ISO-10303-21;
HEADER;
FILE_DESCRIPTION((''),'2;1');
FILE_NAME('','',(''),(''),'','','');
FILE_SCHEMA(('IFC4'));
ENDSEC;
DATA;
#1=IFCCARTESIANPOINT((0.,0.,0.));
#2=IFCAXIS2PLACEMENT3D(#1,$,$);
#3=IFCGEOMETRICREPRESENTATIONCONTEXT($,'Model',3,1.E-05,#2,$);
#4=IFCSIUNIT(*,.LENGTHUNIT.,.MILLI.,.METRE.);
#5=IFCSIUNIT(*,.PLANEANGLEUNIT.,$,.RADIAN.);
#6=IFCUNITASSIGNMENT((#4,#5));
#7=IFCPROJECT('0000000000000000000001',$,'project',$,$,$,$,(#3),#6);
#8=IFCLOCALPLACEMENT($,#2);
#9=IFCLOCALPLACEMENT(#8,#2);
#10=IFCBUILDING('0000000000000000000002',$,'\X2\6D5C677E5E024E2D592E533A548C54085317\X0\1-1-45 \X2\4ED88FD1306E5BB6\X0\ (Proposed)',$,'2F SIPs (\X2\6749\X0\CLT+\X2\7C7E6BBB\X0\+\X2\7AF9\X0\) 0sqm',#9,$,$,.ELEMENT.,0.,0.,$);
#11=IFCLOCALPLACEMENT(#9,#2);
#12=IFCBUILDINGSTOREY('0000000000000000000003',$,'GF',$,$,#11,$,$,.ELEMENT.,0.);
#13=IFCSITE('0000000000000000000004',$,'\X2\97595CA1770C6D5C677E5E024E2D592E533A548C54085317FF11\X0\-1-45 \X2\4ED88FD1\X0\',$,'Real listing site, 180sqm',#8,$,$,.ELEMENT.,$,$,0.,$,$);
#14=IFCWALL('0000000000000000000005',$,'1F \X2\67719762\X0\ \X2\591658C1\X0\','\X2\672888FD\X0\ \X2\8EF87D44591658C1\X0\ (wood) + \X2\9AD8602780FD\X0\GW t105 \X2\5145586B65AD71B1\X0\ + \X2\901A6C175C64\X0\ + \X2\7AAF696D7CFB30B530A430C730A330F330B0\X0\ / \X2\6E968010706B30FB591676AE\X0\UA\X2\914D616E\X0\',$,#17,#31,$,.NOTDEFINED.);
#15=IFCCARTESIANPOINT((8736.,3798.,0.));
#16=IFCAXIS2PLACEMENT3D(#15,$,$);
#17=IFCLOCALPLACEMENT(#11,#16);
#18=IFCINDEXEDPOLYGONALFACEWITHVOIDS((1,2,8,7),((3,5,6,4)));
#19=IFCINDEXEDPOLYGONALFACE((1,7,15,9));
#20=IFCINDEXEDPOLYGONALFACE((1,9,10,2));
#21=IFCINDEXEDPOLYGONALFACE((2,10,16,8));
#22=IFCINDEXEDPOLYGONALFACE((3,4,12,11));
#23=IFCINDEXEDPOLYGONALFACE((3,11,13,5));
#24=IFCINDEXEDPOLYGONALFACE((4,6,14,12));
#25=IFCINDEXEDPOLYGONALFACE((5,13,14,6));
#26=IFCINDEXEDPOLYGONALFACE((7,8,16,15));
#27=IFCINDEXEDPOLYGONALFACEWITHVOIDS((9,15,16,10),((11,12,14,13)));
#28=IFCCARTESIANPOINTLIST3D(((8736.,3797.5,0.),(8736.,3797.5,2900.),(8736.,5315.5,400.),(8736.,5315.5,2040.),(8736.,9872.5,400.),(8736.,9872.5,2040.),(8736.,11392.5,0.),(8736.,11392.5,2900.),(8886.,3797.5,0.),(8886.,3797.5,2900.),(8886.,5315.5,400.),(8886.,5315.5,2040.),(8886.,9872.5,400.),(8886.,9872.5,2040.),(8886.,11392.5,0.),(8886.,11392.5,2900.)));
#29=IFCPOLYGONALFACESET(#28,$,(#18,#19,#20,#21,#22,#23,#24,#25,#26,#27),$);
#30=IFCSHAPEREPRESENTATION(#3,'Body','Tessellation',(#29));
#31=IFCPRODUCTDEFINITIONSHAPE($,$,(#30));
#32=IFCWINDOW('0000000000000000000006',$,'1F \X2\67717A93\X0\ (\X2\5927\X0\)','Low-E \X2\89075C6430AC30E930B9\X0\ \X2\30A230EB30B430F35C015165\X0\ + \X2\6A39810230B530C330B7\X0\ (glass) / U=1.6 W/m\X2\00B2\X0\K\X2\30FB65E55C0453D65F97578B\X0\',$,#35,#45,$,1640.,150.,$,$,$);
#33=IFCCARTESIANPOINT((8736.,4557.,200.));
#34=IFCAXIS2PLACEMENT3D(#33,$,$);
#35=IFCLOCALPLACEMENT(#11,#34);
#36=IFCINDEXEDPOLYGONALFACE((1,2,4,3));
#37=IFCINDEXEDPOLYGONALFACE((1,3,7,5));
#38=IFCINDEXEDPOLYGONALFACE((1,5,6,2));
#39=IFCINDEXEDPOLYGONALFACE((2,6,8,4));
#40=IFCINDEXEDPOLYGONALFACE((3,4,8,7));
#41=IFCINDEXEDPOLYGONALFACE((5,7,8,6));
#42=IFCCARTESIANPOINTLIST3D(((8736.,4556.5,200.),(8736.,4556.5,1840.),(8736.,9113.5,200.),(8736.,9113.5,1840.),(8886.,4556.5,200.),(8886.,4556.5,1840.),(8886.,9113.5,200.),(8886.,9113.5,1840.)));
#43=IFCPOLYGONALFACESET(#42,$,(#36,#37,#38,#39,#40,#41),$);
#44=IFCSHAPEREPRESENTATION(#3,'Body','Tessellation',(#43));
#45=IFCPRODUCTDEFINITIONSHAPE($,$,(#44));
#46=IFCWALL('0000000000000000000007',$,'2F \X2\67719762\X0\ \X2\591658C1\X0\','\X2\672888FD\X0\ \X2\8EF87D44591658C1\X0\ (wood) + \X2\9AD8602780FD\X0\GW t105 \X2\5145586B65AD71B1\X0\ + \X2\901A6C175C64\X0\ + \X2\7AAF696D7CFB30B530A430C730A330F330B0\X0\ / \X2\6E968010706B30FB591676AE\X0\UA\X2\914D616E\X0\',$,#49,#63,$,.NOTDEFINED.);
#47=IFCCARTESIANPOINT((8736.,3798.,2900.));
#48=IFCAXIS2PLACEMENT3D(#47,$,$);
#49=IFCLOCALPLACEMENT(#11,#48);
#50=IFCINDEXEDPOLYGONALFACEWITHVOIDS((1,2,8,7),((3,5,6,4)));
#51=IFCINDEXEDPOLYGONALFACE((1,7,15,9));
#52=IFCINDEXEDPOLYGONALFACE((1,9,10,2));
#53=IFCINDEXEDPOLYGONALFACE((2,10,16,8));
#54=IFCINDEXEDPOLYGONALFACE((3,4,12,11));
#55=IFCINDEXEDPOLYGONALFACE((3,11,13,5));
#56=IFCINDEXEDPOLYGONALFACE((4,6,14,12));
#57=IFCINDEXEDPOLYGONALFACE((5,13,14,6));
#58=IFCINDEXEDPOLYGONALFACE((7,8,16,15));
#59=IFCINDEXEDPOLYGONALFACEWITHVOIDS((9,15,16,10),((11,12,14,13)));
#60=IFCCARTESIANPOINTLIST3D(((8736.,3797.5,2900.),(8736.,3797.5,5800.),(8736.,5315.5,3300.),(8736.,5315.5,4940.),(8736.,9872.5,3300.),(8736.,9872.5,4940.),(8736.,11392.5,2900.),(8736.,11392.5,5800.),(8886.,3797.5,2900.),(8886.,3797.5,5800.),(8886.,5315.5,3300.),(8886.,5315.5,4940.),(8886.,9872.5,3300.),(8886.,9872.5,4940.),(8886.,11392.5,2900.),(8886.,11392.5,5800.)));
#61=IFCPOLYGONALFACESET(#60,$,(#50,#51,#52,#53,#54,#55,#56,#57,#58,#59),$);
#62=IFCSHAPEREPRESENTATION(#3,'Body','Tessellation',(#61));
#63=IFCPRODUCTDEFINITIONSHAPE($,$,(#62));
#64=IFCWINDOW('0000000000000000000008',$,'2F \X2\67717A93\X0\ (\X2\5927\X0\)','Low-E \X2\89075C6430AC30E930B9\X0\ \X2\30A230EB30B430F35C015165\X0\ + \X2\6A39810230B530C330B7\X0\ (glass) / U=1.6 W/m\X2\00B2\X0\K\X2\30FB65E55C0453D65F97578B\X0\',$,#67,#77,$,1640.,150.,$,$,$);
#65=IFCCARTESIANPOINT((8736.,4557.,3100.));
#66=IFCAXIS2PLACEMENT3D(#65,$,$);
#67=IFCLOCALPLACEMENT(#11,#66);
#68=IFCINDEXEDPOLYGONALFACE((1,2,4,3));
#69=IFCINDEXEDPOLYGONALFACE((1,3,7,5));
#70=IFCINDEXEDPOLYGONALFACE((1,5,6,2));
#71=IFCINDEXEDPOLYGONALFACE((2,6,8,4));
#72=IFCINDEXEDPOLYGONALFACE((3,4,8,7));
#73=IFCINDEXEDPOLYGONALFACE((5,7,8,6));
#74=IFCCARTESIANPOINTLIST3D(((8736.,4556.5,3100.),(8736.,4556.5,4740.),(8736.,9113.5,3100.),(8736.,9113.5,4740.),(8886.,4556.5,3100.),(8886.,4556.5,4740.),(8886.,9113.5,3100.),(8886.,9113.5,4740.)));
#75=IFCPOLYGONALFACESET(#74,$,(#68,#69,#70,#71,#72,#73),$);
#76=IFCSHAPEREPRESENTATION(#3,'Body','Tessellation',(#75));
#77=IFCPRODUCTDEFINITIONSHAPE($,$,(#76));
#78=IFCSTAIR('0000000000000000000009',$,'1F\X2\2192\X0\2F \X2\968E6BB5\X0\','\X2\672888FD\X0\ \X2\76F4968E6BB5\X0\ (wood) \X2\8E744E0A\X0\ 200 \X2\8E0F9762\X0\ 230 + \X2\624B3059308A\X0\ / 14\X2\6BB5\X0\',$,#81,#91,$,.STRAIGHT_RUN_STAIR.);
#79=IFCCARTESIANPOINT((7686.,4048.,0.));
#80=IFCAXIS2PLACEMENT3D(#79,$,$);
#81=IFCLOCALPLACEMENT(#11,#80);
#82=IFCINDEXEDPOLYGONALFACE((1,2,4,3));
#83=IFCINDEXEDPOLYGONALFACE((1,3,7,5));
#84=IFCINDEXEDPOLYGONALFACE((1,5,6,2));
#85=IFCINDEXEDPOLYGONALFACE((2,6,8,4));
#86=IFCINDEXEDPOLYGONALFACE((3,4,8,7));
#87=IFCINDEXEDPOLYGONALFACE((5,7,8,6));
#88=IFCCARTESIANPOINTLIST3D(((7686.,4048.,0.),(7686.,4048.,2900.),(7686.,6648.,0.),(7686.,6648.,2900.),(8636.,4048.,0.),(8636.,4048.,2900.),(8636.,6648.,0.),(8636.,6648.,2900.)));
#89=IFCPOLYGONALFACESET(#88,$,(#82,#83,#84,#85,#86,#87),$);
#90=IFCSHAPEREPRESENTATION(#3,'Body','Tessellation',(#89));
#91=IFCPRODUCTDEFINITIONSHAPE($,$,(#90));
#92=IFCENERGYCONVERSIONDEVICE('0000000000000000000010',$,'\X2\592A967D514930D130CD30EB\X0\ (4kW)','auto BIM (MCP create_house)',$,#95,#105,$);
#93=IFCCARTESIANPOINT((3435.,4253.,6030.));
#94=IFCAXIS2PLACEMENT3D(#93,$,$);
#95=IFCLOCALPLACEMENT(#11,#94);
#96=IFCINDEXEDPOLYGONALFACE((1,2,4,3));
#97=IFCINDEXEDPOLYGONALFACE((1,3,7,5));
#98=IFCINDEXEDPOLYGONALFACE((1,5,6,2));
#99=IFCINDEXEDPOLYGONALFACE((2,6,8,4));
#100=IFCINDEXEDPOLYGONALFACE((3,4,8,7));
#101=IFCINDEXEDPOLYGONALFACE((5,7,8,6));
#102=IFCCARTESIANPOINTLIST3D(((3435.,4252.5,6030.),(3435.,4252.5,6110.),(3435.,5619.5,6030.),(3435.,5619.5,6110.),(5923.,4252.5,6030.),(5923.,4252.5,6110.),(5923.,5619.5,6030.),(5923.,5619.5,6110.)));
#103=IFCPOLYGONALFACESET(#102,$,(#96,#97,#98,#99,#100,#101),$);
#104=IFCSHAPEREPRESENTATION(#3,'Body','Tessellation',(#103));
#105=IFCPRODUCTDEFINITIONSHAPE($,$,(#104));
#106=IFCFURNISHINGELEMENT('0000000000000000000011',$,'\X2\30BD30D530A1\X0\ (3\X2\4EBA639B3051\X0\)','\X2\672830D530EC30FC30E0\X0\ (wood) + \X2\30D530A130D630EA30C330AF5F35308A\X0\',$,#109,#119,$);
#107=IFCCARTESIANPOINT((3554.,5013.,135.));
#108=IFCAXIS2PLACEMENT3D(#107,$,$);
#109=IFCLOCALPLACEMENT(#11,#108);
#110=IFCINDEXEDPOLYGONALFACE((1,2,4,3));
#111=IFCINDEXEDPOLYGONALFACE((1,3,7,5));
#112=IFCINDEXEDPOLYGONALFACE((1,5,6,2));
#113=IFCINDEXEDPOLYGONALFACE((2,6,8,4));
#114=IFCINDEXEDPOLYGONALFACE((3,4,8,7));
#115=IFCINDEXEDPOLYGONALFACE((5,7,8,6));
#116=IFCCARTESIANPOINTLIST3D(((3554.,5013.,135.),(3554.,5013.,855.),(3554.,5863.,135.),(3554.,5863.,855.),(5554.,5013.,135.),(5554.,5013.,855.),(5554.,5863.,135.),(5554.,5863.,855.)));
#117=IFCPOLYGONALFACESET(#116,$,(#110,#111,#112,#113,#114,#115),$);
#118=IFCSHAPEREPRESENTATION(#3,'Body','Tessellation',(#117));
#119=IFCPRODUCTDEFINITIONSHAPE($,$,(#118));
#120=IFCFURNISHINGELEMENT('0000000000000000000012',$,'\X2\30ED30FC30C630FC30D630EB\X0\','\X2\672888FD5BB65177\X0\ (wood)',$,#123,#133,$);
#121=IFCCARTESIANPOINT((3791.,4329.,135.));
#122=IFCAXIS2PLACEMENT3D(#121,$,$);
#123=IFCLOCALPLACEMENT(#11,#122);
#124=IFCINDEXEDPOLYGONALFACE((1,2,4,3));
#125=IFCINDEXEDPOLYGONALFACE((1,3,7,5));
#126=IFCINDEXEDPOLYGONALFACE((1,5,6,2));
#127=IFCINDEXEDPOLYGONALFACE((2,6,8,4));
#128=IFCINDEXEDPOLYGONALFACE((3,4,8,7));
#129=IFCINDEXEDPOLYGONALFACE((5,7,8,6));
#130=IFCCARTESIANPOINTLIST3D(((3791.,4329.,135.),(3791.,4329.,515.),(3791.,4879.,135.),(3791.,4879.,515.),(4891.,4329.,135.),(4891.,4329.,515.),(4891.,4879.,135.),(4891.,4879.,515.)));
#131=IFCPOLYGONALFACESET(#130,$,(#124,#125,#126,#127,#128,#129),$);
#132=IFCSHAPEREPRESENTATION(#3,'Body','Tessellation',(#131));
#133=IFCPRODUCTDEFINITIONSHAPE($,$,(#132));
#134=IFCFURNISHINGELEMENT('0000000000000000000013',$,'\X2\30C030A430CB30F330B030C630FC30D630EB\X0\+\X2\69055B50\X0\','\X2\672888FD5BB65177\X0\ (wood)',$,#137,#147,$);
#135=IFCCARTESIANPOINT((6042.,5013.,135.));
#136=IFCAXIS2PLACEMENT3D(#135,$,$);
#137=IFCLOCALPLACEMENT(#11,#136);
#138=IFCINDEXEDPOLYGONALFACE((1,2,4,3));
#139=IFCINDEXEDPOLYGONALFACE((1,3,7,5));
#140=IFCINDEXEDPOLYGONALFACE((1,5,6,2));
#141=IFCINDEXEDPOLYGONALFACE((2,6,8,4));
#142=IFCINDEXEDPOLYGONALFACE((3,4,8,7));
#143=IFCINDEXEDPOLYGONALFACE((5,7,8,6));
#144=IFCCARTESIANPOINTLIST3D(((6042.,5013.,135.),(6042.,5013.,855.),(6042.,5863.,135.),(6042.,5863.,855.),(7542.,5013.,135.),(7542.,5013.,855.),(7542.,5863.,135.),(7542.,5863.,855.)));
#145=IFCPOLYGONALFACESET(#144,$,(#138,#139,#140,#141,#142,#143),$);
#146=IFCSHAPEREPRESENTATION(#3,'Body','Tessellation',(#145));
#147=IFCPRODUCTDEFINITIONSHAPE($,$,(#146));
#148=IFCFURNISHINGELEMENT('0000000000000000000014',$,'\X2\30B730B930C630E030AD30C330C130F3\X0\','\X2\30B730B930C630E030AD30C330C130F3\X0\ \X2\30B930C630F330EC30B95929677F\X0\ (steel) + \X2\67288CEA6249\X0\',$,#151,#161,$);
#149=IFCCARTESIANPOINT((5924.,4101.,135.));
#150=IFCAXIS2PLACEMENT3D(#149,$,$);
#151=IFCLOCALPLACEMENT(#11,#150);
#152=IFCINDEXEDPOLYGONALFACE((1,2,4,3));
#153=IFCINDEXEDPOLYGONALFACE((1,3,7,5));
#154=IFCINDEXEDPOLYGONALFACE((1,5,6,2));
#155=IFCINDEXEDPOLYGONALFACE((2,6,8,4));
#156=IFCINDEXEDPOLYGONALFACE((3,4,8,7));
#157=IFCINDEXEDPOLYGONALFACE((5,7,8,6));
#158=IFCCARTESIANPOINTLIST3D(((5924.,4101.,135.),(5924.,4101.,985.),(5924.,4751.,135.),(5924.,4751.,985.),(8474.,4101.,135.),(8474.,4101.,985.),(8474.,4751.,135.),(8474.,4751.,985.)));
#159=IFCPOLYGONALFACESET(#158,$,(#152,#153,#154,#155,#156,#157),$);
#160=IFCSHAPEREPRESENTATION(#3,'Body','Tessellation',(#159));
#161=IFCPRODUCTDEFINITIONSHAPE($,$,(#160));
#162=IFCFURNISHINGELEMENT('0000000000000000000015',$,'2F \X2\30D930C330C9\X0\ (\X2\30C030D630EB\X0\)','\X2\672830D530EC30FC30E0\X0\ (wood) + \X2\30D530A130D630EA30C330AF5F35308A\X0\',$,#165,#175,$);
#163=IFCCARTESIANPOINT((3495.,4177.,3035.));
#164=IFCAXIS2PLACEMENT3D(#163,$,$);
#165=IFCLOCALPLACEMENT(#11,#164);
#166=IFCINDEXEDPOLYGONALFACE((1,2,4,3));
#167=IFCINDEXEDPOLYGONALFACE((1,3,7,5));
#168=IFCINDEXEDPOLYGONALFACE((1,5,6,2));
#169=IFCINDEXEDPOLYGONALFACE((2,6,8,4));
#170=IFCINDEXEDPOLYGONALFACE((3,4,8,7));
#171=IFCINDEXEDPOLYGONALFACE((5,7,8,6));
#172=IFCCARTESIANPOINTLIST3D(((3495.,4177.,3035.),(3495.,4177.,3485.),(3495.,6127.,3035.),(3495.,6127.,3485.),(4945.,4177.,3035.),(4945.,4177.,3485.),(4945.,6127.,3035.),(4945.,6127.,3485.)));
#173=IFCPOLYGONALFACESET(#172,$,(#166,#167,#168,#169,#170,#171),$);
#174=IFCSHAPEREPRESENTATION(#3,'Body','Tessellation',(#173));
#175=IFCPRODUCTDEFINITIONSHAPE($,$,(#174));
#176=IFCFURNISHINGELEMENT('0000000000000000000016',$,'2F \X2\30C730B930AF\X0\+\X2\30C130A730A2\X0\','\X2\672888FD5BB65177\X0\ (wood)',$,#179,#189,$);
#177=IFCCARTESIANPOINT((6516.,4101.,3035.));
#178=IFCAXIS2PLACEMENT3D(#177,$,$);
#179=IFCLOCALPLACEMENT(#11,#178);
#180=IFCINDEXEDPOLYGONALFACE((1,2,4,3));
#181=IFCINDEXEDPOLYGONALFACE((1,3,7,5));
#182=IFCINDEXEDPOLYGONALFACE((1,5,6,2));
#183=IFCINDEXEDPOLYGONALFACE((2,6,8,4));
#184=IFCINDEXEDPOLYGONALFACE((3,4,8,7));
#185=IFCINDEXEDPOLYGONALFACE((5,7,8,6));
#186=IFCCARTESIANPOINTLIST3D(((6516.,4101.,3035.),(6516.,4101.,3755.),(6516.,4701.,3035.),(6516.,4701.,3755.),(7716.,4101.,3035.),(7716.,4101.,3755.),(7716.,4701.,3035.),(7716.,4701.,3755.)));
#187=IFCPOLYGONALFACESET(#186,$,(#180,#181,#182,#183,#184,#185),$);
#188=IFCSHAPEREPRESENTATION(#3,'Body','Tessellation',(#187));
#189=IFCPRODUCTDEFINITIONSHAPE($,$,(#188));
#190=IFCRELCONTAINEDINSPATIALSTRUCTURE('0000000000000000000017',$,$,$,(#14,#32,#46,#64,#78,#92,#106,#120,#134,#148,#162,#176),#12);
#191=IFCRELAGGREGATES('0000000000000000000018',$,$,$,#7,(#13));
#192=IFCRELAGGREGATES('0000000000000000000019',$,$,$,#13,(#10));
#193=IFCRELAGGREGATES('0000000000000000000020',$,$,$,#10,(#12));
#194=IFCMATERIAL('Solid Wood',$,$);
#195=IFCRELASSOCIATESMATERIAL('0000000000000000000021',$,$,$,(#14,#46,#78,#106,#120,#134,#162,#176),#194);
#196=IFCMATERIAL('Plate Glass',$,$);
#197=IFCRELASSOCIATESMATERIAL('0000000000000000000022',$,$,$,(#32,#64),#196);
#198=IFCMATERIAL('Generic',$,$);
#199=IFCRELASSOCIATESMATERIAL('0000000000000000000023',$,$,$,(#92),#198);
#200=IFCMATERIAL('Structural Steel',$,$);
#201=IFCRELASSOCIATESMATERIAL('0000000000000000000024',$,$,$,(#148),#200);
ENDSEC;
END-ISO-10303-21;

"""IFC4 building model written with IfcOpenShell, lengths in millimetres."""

from ifc_helpers import new_model, si_unit, frame, frame_2d, origin, place, context, project, spatial, rectangle, extrude, material, element, fill, save


model = new_model("IFC4")

# Units and contexts
model_context = context("Model", 3, precision=1e-05, world=origin())
ifc_project = project(units=[si_unit("LENGTHUNIT", "METRE", prefix="MILLI"), si_unit("PLANEANGLEUNIT", "RADIAN")], contexts=[model_context])

# Site, building, storey
site_placement = place(None, origin())
site = spatial("IfcSite", under=ifc_project, at=site_placement, Name="静岡県浜松市中央区和合北１-1-45 付近", ObjectType="Real listing site, 180sqm", CompositionType="ELEMENT", RefElevation=0.0)
building_placement = place(site_placement, origin())
building = spatial("IfcBuilding", under=site, at=building_placement, Name="浜松市中央区和合北1-1-45 付近の家 (Proposed)", ObjectType="2F SIPs (杉CLT+籾殻+竹) 0sqm", CompositionType="ELEMENT", ElevationOfRefHeight=0.0, ElevationOfTerrain=0.0)
storey_placement = place(building_placement, origin())
storey = spatial("IfcBuildingStorey", under=building, at=storey_placement, Name="GF", CompositionType="ELEMENT", Elevation=0.0)

# Wall, opening, window
ifc_material_1 = material(Name="Solid Wood")
wall_1_placement = place(storey_placement, frame((8736.0, 3798.0, 0.0)))
wall_1 = element("IfcWall", 1, at=wall_1_placement, inside=storey, material=ifc_material_1, Name="1F 東面 外壁", Description="木製 軸組外壁 (wood) + 高性能GW t105 充填断熱 + 通気層 + 窯業系サイディング / 準耐火・外皮UA配慮", PredefinedType="NOTDEFINED", context=model_context, shape_type="SweptSolid", body=[
    extrude(rectangle(XDim=150.0, YDim=7595.0, at=frame_2d((75.0, 3797.0))), frame((8736.0, 3798.0, 0.0)), (0.0, 0.0, 1.0), 2900.0),
])
opening_1_placement = place(storey_placement, frame((8736.0, 4557.0, 200.0)))
opening_1 = element("IfcOpeningElement", 2, at=opening_1_placement, cuts=wall_1, PredefinedType="NOTDEFINED", context=model_context, shape_type="SweptSolid", body=[
    extrude(rectangle(XDim=150.0, YDim=4557.0, at=frame_2d((75.0, 2278.0))), frame((8736.0, 4557.0, 200.0)), (0.0, 0.0, 1.0), 1640.0),
])
ifc_material_2 = material(Name="Plate Glass")
window_1_placement = place(storey_placement, frame((8736.0, 4557.0, 200.0)))
window_1 = element("IfcWindow", 3, at=window_1_placement, inside=storey, material=ifc_material_2, Name="1F 東窓 (大)", Description="Low-E 複層ガラス アルゴン封入 + 樹脂サッシ (glass) / U=1.6 W/m²K・日射取得型", OverallHeight=1640.0, OverallWidth=150.0, context=model_context, shape_type="SweptSolid", body=[
    extrude(rectangle(XDim=150.0, YDim=4557.0, at=frame_2d((75.0, 2278.0))), frame((8736.0, 4557.0, 200.0)), (0.0, 0.0, 1.0), 1640.0),
])
fill(opening_1, window_1)

# Wall, opening, window
wall_2_placement = place(storey_placement, frame((8736.0, 3798.0, 2900.0)))
wall_2 = element("IfcWall", 4, at=wall_2_placement, inside=storey, material=ifc_material_1, Name="2F 東面 外壁", Description="木製 軸組外壁 (wood) + 高性能GW t105 充填断熱 + 通気層 + 窯業系サイディング / 準耐火・外皮UA配慮", PredefinedType="NOTDEFINED", context=model_context, shape_type="SweptSolid", body=[
    extrude(rectangle(XDim=150.0, YDim=7595.0, at=frame_2d((75.0, 3797.0))), frame((8736.0, 3798.0, 2900.0)), (0.0, 0.0, 1.0), 2900.0),
])
opening_2_placement = place(storey_placement, frame((8736.0, 4557.0, 3100.0)))
opening_2 = element("IfcOpeningElement", 5, at=opening_2_placement, cuts=wall_2, PredefinedType="NOTDEFINED", context=model_context, shape_type="SweptSolid", body=[
    extrude(rectangle(XDim=150.0, YDim=4557.0, at=frame_2d((75.0, 2278.0))), frame((8736.0, 4557.0, 3100.0)), (0.0, 0.0, 1.0), 1640.0),
])
window_2_placement = place(storey_placement, frame((8736.0, 4557.0, 3100.0)))
window_2 = element("IfcWindow", 6, at=window_2_placement, inside=storey, material=ifc_material_2, Name="2F 東窓 (大)", Description="Low-E 複層ガラス アルゴン封入 + 樹脂サッシ (glass) / U=1.6 W/m²K・日射取得型", OverallHeight=1640.0, OverallWidth=150.0, context=model_context, shape_type="SweptSolid", body=[
    extrude(rectangle(XDim=150.0, YDim=4557.0, at=frame_2d((75.0, 2278.0))), frame((8736.0, 4557.0, 3100.0)), (0.0, 0.0, 1.0), 1640.0),
])
fill(opening_2, window_2)

# Stair
stair_placement = place(storey_placement, frame((7686.0, 4048.0, 0.0)))
element("IfcStair", 7, at=stair_placement, inside=storey, material=ifc_material_1, Name="1F→2F 階段", Description="木製 直階段 (wood) 蹴上 200 踏面 230 + 手すり / 14段", PredefinedType="STRAIGHT_RUN_STAIR", context=model_context, shape_type="SweptSolid", body=[
    extrude(rectangle(XDim=950.0, YDim=2600.0, at=frame_2d((475.0, 1300.0))), frame((7686.0, 4048.0, 0.0)), (0.0, 0.0, 1.0), 2900.0),
])

# Energy conversion device
ifc_material_3 = material(Name="Generic")
energy_conversion_device_placement = place(storey_placement, frame((3435.0, 4253.0, 6030.0)))
element("IfcEnergyConversionDevice", 8, at=energy_conversion_device_placement, inside=storey, material=ifc_material_3, Name="太陽光パネル (4kW)", Description="auto BIM (MCP create_house)", context=model_context, shape_type="SweptSolid", body=[
    extrude(rectangle(XDim=2488.0, YDim=1367.0, at=frame_2d((1244.0, 683.0))), frame((3435.0, 4253.0, 6030.0)), (0.0, 0.0, 1.0), 80.0),
])

# Furnishing elements
furnishing_1_placement = place(storey_placement, frame((3554.0, 5013.0, 135.0)))
element("IfcFurnishingElement", 9, at=furnishing_1_placement, inside=storey, material=ifc_material_1, Name="ソファ (3人掛け)", Description="木フレーム (wood) + ファブリック張り", context=model_context, shape_type="SweptSolid", body=[
    extrude(rectangle(XDim=2000.0, YDim=850.0, at=frame_2d((1000.0, 425.0))), frame((3554.0, 5013.0, 135.0)), (0.0, 0.0, 1.0), 720.0),
])
furnishing_2_placement = place(storey_placement, frame((3791.0, 4329.0, 135.0)))
element("IfcFurnishingElement", 10, at=furnishing_2_placement, inside=storey, material=ifc_material_1, Name="ローテーブル", Description="木製家具 (wood)", context=model_context, shape_type="SweptSolid", body=[
    extrude(rectangle(XDim=1100.0, YDim=550.0, at=frame_2d((550.0, 275.0))), frame((3791.0, 4329.0, 135.0)), (0.0, 0.0, 1.0), 380.0),
])
furnishing_3_placement = place(storey_placement, frame((6042.0, 5013.0, 135.0)))
element("IfcFurnishingElement", 11, at=furnishing_3_placement, inside=storey, material=ifc_material_1, Name="ダイニングテーブル+椅子", Description="木製家具 (wood)", context=model_context, shape_type="SweptSolid", body=[
    extrude(rectangle(XDim=1500.0, YDim=850.0, at=frame_2d((750.0, 425.0))), frame((6042.0, 5013.0, 135.0)), (0.0, 0.0, 1.0), 720.0),
])
ifc_material_4 = material(Name="Structural Steel")
furnishing_4_placement = place(storey_placement, frame((5924.0, 4101.0, 135.0)))
element("IfcFurnishingElement", 12, at=furnishing_4_placement, inside=storey, material=ifc_material_4, Name="システムキッチン", Description="システムキッチン ステンレス天板 (steel) + 木質扉", context=model_context, shape_type="SweptSolid", body=[
    extrude(rectangle(XDim=2550.0, YDim=650.0, at=frame_2d((1275.0, 325.0))), frame((5924.0, 4101.0, 135.0)), (0.0, 0.0, 1.0), 850.0),
])
furnishing_5_placement = place(storey_placement, frame((3495.0, 4177.0, 3035.0)))
element("IfcFurnishingElement", 13, at=furnishing_5_placement, inside=storey, material=ifc_material_1, Name="2F ベッド (ダブル)", Description="木フレーム (wood) + ファブリック張り", context=model_context, shape_type="SweptSolid", body=[
    extrude(rectangle(XDim=1450.0, YDim=1950.0, at=frame_2d((725.0, 975.0))), frame((3495.0, 4177.0, 3035.0)), (0.0, 0.0, 1.0), 450.0),
])
furnishing_6_placement = place(storey_placement, frame((6516.0, 4101.0, 3035.0)))
element("IfcFurnishingElement", 14, at=furnishing_6_placement, inside=storey, material=ifc_material_1, Name="2F デスク+チェア", Description="木製家具 (wood)", context=model_context, shape_type="SweptSolid", body=[
    extrude(rectangle(XDim=1200.0, YDim=600.0, at=frame_2d((600.0, 300.0))), frame((6516.0, 4101.0, 3035.0)), (0.0, 0.0, 1.0), 720.0),
])

save(model, "model.ifc")
